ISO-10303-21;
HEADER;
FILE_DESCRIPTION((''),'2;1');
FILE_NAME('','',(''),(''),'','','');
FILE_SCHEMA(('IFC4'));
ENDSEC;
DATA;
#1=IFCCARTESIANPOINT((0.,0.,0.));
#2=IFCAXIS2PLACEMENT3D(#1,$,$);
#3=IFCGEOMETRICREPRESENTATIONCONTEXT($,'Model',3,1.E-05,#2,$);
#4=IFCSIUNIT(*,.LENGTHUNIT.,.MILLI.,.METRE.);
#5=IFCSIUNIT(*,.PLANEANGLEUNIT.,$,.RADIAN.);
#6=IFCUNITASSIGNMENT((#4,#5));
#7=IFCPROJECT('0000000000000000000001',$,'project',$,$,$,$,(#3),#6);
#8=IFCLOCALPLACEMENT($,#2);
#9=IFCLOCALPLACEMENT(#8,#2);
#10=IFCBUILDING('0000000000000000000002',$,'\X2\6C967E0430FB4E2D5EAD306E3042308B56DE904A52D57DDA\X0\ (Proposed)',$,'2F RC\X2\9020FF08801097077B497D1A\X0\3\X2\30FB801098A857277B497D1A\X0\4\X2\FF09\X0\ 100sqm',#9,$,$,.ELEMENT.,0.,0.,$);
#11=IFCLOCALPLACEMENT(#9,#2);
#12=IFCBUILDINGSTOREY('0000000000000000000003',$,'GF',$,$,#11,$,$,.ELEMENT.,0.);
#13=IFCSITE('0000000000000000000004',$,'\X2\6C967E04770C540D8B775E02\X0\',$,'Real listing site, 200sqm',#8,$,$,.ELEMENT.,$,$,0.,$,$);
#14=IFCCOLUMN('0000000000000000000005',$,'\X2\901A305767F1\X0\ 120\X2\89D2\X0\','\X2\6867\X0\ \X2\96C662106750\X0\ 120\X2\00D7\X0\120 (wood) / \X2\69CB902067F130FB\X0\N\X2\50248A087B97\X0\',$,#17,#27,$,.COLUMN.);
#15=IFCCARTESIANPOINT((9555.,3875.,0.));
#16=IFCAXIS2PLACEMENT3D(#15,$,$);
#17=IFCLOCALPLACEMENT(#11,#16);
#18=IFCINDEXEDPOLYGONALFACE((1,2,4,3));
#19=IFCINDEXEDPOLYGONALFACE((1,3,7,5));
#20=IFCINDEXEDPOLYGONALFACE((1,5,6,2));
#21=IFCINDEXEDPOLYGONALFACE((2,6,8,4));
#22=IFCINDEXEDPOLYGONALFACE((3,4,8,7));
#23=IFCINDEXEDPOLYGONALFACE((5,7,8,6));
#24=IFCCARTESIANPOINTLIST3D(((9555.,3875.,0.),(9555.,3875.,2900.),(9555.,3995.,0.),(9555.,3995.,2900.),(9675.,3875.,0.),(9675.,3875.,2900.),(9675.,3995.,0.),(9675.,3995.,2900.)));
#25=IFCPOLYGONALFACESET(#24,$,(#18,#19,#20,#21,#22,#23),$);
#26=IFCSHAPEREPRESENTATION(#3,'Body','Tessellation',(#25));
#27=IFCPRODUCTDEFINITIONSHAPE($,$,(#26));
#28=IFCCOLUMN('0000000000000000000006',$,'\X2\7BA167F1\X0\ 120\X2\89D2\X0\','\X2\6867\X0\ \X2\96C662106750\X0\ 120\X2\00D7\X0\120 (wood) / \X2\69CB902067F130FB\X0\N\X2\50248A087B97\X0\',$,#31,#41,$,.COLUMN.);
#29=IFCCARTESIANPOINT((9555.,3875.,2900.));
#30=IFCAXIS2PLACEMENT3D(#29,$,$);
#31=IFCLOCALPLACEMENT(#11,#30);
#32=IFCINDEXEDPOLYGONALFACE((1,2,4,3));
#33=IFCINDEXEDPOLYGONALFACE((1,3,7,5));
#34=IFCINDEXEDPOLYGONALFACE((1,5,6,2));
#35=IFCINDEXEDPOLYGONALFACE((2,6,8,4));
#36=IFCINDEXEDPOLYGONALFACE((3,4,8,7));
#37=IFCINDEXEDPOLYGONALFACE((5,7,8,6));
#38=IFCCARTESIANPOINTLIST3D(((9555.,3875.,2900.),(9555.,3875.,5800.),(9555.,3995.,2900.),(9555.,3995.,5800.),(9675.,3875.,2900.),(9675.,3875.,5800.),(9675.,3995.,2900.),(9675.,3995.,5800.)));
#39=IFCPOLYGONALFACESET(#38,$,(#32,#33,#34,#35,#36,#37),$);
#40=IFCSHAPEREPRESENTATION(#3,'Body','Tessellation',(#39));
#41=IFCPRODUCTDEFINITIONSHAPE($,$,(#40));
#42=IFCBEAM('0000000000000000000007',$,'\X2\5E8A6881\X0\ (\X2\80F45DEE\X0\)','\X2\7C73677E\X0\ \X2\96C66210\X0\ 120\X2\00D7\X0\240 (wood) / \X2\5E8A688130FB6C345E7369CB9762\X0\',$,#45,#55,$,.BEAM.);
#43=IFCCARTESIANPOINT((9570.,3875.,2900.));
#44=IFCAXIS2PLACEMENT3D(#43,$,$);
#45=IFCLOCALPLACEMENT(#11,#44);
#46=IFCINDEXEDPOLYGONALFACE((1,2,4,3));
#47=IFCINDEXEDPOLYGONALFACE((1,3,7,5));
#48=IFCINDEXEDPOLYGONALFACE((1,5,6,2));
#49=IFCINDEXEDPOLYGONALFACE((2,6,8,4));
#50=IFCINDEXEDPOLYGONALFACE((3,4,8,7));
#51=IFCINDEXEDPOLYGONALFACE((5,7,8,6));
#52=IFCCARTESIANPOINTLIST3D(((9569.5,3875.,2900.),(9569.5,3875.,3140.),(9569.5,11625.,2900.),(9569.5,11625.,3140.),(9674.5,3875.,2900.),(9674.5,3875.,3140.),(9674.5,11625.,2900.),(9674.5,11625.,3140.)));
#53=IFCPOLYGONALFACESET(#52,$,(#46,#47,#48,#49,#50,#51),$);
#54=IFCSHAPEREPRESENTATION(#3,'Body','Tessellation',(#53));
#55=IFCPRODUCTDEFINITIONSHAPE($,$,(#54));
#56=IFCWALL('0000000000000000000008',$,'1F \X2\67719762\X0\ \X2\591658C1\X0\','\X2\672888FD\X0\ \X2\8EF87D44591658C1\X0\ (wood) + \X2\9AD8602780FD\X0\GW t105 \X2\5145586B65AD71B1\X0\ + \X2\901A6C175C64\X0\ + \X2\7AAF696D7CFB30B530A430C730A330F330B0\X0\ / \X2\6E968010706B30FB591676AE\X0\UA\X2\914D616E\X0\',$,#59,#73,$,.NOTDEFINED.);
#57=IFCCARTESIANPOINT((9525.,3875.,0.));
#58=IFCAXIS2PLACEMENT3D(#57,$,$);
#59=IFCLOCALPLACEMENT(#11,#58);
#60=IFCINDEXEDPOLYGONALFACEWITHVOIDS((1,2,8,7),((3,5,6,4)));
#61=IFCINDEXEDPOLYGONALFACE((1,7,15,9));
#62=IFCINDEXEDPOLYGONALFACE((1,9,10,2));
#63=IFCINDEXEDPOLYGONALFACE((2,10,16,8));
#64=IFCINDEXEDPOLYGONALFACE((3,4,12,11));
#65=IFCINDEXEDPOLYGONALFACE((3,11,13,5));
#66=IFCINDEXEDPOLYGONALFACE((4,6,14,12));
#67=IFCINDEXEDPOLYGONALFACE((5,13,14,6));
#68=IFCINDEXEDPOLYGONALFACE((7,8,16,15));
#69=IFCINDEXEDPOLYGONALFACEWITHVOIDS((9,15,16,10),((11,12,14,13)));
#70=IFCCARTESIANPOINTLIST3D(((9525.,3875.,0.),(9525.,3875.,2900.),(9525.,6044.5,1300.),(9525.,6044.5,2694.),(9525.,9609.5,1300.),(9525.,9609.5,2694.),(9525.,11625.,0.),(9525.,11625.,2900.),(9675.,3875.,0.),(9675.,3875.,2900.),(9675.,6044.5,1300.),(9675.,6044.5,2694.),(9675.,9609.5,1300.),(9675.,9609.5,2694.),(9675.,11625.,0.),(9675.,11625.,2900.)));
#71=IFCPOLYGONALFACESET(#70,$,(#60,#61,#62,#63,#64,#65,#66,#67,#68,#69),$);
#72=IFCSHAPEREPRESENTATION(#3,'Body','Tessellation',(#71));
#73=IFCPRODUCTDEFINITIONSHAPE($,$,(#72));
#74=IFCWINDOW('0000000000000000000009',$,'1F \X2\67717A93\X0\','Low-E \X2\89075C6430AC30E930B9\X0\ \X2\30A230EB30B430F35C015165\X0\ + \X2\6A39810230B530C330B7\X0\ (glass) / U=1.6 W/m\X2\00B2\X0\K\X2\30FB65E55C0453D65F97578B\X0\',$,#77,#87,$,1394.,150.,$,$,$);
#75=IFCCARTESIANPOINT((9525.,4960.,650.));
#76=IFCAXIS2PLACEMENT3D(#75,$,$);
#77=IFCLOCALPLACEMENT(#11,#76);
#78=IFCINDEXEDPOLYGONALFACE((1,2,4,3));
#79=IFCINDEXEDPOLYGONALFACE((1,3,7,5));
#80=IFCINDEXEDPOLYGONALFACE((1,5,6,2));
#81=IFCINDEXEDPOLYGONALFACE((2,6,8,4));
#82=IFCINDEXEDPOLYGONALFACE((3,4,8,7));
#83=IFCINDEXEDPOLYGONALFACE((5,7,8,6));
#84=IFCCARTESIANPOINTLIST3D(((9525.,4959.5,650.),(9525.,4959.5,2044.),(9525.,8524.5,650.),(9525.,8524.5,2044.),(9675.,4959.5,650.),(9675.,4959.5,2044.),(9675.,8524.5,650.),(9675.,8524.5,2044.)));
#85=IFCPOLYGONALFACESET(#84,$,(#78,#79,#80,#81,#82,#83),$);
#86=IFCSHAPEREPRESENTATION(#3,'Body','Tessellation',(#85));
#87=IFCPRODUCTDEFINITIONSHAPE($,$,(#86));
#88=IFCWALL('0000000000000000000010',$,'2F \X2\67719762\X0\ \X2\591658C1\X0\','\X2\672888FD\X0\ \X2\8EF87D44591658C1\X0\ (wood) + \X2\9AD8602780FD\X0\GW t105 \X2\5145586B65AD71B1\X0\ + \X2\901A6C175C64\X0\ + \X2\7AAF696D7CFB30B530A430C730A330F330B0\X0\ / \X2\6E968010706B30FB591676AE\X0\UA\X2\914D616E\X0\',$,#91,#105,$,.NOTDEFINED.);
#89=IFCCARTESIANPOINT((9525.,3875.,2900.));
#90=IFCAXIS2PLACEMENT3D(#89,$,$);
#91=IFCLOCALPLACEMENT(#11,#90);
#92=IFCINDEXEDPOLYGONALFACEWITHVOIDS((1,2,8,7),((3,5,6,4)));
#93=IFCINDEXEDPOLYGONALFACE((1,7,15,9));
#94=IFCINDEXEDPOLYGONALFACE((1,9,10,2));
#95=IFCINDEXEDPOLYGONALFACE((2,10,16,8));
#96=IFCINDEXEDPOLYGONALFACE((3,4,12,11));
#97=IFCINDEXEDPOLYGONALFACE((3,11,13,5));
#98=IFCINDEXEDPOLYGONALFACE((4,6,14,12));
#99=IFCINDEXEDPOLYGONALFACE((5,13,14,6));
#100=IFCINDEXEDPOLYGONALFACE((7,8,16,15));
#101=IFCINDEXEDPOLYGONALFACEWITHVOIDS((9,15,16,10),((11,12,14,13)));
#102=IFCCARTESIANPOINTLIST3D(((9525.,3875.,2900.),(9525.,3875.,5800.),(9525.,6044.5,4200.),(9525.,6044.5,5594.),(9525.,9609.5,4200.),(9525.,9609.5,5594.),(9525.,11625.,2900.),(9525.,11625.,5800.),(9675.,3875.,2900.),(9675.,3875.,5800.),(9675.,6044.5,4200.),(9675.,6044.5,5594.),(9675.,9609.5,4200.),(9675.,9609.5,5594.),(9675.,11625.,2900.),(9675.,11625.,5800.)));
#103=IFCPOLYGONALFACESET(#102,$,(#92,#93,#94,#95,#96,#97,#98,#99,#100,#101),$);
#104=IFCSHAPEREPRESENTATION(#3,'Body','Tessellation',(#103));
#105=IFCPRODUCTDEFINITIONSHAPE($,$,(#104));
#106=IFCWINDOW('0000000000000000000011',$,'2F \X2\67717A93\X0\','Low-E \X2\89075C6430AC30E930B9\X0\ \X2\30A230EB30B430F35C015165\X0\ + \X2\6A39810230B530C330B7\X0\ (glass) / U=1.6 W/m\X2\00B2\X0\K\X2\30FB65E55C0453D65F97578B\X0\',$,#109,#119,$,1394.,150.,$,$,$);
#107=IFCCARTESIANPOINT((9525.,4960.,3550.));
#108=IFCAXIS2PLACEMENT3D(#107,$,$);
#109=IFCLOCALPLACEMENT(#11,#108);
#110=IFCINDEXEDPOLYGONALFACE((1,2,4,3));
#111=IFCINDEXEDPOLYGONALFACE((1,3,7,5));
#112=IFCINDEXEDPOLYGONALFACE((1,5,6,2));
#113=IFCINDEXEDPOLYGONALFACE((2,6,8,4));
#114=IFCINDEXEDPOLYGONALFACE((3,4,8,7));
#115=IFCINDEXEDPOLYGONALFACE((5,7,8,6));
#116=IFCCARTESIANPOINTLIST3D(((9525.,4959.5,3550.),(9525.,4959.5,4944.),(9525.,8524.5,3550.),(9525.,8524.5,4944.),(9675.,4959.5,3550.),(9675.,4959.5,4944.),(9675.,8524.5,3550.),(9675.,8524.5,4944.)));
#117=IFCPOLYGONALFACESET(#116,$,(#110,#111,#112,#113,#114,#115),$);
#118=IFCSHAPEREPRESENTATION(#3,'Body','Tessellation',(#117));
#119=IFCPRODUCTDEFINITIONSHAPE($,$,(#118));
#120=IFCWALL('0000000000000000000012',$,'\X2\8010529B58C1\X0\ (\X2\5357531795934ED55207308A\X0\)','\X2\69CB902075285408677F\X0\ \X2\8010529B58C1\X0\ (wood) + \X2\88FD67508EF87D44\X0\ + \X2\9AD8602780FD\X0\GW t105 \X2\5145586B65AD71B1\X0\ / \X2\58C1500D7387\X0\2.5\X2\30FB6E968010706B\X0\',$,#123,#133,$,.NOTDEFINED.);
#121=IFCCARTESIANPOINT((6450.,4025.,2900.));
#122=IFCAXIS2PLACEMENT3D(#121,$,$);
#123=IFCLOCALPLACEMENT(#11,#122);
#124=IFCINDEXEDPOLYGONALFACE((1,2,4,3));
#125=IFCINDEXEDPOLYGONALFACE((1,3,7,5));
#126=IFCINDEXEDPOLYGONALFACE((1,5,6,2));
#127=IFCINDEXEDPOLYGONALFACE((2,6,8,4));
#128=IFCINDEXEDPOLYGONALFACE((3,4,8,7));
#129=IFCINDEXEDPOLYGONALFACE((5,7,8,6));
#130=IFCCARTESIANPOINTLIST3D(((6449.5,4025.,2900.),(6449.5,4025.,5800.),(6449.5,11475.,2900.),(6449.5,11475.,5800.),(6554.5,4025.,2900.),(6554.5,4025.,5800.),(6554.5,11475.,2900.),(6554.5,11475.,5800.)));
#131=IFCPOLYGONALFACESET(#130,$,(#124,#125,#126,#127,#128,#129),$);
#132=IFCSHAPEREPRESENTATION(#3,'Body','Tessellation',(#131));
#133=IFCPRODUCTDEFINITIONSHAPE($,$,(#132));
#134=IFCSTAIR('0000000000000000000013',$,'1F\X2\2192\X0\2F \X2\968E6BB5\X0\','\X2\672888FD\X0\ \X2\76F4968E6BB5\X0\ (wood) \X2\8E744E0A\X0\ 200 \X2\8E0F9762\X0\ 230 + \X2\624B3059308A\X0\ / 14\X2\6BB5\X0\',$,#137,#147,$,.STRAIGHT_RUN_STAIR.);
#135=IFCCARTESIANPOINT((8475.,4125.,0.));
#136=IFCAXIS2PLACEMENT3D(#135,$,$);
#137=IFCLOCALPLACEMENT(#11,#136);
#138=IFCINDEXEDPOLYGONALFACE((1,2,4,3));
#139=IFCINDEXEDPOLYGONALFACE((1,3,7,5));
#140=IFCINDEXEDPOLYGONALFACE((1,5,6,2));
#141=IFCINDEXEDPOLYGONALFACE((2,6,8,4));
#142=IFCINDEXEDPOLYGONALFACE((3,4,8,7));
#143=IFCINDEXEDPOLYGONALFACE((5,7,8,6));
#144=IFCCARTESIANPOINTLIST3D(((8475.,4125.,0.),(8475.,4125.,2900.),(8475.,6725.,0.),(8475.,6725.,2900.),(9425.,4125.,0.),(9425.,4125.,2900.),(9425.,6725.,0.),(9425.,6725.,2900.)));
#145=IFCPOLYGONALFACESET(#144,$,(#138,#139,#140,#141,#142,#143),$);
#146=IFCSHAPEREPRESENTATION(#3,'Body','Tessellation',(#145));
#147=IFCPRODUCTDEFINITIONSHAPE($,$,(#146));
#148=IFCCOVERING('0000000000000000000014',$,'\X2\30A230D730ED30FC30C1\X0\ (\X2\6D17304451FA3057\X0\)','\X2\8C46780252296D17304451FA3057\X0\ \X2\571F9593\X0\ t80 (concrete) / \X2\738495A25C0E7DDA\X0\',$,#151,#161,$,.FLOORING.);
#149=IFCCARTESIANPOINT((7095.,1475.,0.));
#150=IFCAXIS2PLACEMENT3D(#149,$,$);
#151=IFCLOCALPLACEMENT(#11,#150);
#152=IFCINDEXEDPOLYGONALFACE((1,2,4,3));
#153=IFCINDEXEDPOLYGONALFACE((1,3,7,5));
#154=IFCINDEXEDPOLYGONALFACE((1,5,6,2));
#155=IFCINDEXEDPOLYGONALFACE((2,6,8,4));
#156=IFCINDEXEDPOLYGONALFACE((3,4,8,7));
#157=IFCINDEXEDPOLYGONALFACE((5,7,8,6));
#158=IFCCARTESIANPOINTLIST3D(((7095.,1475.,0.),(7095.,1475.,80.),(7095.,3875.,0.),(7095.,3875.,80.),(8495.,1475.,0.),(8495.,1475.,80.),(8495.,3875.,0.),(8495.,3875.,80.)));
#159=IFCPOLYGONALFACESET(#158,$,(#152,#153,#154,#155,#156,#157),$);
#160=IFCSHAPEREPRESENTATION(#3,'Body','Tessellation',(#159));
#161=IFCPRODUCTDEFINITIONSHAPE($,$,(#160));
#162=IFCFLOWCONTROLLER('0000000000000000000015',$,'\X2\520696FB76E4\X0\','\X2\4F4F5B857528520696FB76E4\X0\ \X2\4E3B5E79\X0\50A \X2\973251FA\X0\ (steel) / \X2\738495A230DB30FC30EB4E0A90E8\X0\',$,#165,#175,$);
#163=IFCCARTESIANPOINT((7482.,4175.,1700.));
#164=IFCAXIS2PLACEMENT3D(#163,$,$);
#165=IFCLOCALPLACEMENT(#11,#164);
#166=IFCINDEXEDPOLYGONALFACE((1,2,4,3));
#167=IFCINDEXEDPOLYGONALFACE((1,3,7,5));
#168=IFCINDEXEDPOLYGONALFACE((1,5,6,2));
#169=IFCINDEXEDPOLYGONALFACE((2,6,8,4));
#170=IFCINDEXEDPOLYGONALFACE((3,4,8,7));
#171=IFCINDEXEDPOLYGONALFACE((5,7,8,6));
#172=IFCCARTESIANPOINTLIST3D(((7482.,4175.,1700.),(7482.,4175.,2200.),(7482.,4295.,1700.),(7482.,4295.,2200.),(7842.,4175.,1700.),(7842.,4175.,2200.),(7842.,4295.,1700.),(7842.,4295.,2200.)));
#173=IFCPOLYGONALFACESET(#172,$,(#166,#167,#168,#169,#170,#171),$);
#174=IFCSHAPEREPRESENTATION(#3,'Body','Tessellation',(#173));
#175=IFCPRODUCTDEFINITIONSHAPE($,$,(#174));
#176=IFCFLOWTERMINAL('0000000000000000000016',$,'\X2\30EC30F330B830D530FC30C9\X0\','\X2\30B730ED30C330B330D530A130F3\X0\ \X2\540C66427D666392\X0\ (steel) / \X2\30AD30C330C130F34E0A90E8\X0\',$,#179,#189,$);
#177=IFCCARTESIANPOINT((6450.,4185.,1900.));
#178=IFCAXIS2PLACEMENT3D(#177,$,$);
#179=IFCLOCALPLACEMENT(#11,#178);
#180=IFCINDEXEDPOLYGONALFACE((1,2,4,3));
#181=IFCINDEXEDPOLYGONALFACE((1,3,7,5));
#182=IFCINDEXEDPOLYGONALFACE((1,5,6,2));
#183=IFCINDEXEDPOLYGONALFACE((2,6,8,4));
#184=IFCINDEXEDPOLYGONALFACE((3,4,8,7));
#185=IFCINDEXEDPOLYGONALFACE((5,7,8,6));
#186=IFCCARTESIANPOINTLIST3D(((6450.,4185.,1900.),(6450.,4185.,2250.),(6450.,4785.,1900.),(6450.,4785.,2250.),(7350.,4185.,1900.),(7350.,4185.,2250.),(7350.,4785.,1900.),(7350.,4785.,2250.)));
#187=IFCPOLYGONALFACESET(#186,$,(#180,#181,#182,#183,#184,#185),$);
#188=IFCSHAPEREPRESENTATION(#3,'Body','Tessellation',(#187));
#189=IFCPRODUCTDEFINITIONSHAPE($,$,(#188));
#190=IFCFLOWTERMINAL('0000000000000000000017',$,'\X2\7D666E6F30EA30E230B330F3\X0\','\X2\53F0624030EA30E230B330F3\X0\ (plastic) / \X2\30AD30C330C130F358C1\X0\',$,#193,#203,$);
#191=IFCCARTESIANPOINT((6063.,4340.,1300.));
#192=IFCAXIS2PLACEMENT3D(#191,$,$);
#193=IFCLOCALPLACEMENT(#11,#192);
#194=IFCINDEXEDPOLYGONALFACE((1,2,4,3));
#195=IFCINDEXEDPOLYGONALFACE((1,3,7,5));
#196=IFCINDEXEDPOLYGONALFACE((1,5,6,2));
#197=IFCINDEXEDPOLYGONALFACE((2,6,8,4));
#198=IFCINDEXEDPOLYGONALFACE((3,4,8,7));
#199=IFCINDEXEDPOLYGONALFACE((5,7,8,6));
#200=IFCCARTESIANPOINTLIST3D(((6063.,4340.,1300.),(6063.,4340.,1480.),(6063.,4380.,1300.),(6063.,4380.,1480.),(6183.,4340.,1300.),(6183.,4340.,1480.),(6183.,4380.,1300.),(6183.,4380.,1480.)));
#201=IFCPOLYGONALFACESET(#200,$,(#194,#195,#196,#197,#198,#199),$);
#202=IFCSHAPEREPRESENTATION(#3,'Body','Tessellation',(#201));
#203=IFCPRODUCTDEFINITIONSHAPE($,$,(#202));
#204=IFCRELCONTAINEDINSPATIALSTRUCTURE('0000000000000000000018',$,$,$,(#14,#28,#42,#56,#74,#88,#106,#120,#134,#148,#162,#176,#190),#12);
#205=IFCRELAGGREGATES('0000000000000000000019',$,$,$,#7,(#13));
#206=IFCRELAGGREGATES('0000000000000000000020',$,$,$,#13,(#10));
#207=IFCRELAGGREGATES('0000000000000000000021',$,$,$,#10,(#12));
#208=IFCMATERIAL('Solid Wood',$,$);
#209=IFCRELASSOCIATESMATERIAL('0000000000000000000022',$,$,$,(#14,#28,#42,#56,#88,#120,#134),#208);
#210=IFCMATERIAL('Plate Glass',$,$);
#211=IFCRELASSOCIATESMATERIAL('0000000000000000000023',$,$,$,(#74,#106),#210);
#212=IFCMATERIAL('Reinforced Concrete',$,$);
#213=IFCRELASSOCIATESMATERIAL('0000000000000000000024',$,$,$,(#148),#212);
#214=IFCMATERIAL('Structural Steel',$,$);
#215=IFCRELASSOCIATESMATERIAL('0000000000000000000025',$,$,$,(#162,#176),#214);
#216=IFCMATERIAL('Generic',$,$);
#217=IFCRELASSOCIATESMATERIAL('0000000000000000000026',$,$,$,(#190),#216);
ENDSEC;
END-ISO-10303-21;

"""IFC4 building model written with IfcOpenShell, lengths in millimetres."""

from ifc_helpers import new_model, si_unit, frame, frame_2d, origin, place, context, project, spatial, rectangle, extrude, material, element, fill, save


model = new_model("IFC4")

# Units and contexts
model_context = context("Model", 3, precision=1e-05, world=origin())
ifc_project = project(units=[si_unit("LENGTHUNIT", "METRE", prefix="MILLI"), si_unit("PLANEANGLEUNIT", "RADIAN")], contexts=[model_context])

# Site, building, storey
site_placement = place(None, origin())
site = spatial("IfcSite", under=ifc_project, at=site_placement, Name="沖縄県名護市", ObjectType="Real listing site, 200sqm", CompositionType="ELEMENT", RefElevation=0.0)
building_placement = place(site_placement, origin())
building = spatial("IfcBuilding", under=site, at=building_placement, Name="沖縄・中庭のある回遊動線 (Proposed)", ObjectType="2F RC造（耐震等級3・耐風圧等級4） 100sqm", CompositionType="ELEMENT", ElevationOfRefHeight=0.0, ElevationOfTerrain=0.0)
storey_placement = place(building_placement, origin())
storey = spatial("IfcBuildingStorey", under=building, at=storey_placement, Name="GF", CompositionType="ELEMENT", Elevation=0.0)

# Columns
ifc_material_1 = material(Name="Solid Wood")
column_1_placement = place(storey_placement, frame((9555.0, 3875.0, 0.0)))
element("IfcColumn", 1, at=column_1_placement, inside=storey, material=ifc_material_1, Name="通し柱 120角", Description="桧 集成材 120×120 (wood) / 構造柱・N値計算", PredefinedType="COLUMN", context=model_context, shape_type="SweptSolid", body=[
    extrude(rectangle(XDim=120.0, YDim=120.0, at=frame_2d((60.0, 60.0))), frame((9555.0, 3875.0, 0.0)), (0.0, 0.0, 1.0), 2900.0),
])
column_2_placement = place(storey_placement, frame((9555.0, 3875.0, 2900.0)))
element("IfcColumn", 2, at=column_2_placement, inside=storey, material=ifc_material_1, Name="管柱 120角", Description="桧 集成材 120×120 (wood) / 構造柱・N値計算", PredefinedType="COLUMN", context=model_context, shape_type="SweptSolid", body=[
    extrude(rectangle(XDim=120.0, YDim=120.0, at=frame_2d((60.0, 60.0))), frame((9555.0, 3875.0, 2900.0)), (0.0, 0.0, 1.0), 2900.0),
])

# Beam
beam_1_placement = place(storey_placement, frame((9570.0, 3875.0, 2900.0)))
element("IfcBeam", 3, at=beam_1_placement, inside=storey, material=ifc_material_1, Name="床梁 (胴差)", Description="米松 集成 120×240 (wood) / 床梁・水平構面", PredefinedType="BEAM", context=model_context, shape_type="SweptSolid", body=[
    extrude(rectangle(XDim=105.0, YDim=7750.0, at=frame_2d((52.0, 3875.0))), frame((9570.0, 3875.0, 2900.0)), (0.0, 0.0, 1.0), 240.0),
])

# Wall, opening, window
wall_1_placement = place(storey_placement, frame((9525.0, 3875.0, 0.0)))
wall_1 = element("IfcWall", 4, at=wall_1_placement, inside=storey, material=ifc_material_1, Name="1F 東面 外壁", Description="木製 軸組外壁 (wood) + 高性能GW t105 充填断熱 + 通気層 + 窯業系サイディング / 準耐火・外皮UA配慮", PredefinedType="NOTDEFINED", context=model_context, shape_type="SweptSolid", body=[
    extrude(rectangle(XDim=150.0, YDim=7750.0, at=frame_2d((75.0, 3875.0))), frame((9525.0, 3875.0, 0.0)), (0.0, 0.0, 1.0), 2900.0),
])
opening_1_placement = place(storey_placement, frame((9525.0, 4960.0, 650.0)))
opening_1 = element("IfcOpeningElement", 5, at=opening_1_placement, cuts=wall_1, PredefinedType="NOTDEFINED", context=model_context, shape_type="SweptSolid", body=[
    extrude(rectangle(XDim=150.0, YDim=3565.0, at=frame_2d((75.0, 1782.0))), frame((9525.0, 4960.0, 650.0)), (0.0, 0.0, 1.0), 1394.0),
])
ifc_material_2 = material(Name="Plate Glass")
window_1_placement = place(storey_placement, frame((9525.0, 4960.0, 650.0)))
window_1 = element("IfcWindow", 6, at=window_1_placement, inside=storey, material=ifc_material_2, Name="1F 東窓", Description="Low-E 複層ガラス アルゴン封入 + 樹脂サッシ (glass) / U=1.6 W/m²K・日射取得型", OverallHeight=1394.0, OverallWidth=150.0, context=model_context, shape_type="SweptSolid", body=[
    extrude(rectangle(XDim=150.0, YDim=3565.0, at=frame_2d((75.0, 1782.0))), frame((9525.0, 4960.0, 650.0)), (0.0, 0.0, 1.0), 1394.0),
])
fill(opening_1, window_1)

# Wall, opening, window
wall_2_placement = place(storey_placement, frame((9525.0, 3875.0, 2900.0)))
wall_2 = element("IfcWall", 7, at=wall_2_placement, inside=storey, material=ifc_material_1, Name="2F 東面 外壁", Description="木製 軸組外壁 (wood) + 高性能GW t105 充填断熱 + 通気層 + 窯業系サイディング / 準耐火・外皮UA配慮", PredefinedType="NOTDEFINED", context=model_context, shape_type="SweptSolid", body=[
    extrude(rectangle(XDim=150.0, YDim=7750.0, at=frame_2d((75.0, 3875.0))), frame((9525.0, 3875.0, 2900.0)), (0.0, 0.0, 1.0), 2900.0),
])
opening_2_placement = place(storey_placement, frame((9525.0, 4960.0, 3550.0)))
opening_2 = element("IfcOpeningElement", 8, at=opening_2_placement, cuts=wall_2, PredefinedType="NOTDEFINED", context=model_context, shape_type="SweptSolid", body=[
    extrude(rectangle(XDim=150.0, YDim=3565.0, at=frame_2d((75.0, 1782.0))), frame((9525.0, 4960.0, 3550.0)), (0.0, 0.0, 1.0), 1394.0),
])
window_2_placement = place(storey_placement, frame((9525.0, 4960.0, 3550.0)))
window_2 = element("IfcWindow", 9, at=window_2_placement, inside=storey, material=ifc_material_2, Name="2F 東窓", Description="Low-E 複層ガラス アルゴン封入 + 樹脂サッシ (glass) / U=1.6 W/m²K・日射取得型", OverallHeight=1394.0, OverallWidth=150.0, context=model_context, shape_type="SweptSolid", body=[
    extrude(rectangle(XDim=150.0, YDim=3565.0, at=frame_2d((75.0, 1782.0))), frame((9525.0, 4960.0, 3550.0)), (0.0, 0.0, 1.0), 1394.0),
])
fill(opening_2, window_2)

# Wall
wall_3_placement = place(storey_placement, frame((6450.0, 4025.0, 2900.0)))
element("IfcWall", 10, at=wall_3_placement, inside=storey, material=ifc_material_1, Name="耐力壁 (南北間仕切り)", Description="構造用合板 耐力壁 (wood) + 製材軸組 + 高性能GW t105 充填断熱 / 壁倍率2.5・準耐火", PredefinedType="NOTDEFINED", context=model_context, shape_type="SweptSolid", body=[
    extrude(rectangle(XDim=105.0, YDim=7450.0, at=frame_2d((52.0, 3725.0))), frame((6450.0, 4025.0, 2900.0)), (0.0, 0.0, 1.0), 2900.0),
])

# Stair
stair_placement = place(storey_placement, frame((8475.0, 4125.0, 0.0)))
element("IfcStair", 11, at=stair_placement, inside=storey, material=ifc_material_1, Name="1F→2F 階段", Description="木製 直階段 (wood) 蹴上 200 踏面 230 + 手すり / 14段", PredefinedType="STRAIGHT_RUN_STAIR", context=model_context, shape_type="SweptSolid", body=[
    extrude(rectangle(XDim=950.0, YDim=2600.0, at=frame_2d((475.0, 1300.0))), frame((8475.0, 4125.0, 0.0)), (0.0, 0.0, 1.0), 2900.0),
])

# Covering
ifc_material_3 = material(Name="Reinforced Concrete")
covering_placement = place(storey_placement, frame((7095.0, 1475.0, 0.0)))
element("IfcCovering", 12, at=covering_placement, inside=storey, material=ifc_material_3, Name="アプローチ (洗い出し)", Description="豆砂利洗い出し 土間 t80 (concrete) / 玄関導線", PredefinedType="FLOORING", context=model_context, shape_type="SweptSolid", body=[
    extrude(rectangle(XDim=1400.0, YDim=2400.0, at=frame_2d((700.0, 1200.0))), frame((7095.0, 1475.0, 0.0)), (0.0, 0.0, 1.0), 80.0),
])

# Flow controller
ifc_material_4 = material(Name="Structural Steel")
flow_controller_placement = place(storey_placement, frame((7482.0, 4175.0, 1700.0)))
element("IfcFlowController", 13, at=flow_controller_placement, inside=storey, material=ifc_material_4, Name="分電盤", Description="住宅用分電盤 主幹50A 露出 (steel) / 玄関ホール上部", context=model_context, shape_type="SweptSolid", body=[
    extrude(rectangle(XDim=360.0, YDim=120.0, at=frame_2d((180.0, 60.0))), frame((7482.0, 4175.0, 1700.0)), (0.0, 0.0, 1.0), 500.0),
])

# Flow terminals
flow_terminal_1_placement = place(storey_placement, frame((6450.0, 4185.0, 1900.0)))
element("IfcFlowTerminal", 14, at=flow_terminal_1_placement, inside=storey, material=ifc_material_4, Name="レンジフード", Description="シロッコファン 同時給排 (steel) / キッチン上部", context=model_context, shape_type="SweptSolid", body=[
    extrude(rectangle(XDim=900.0, YDim=600.0, at=frame_2d((450.0, 300.0))), frame((6450.0, 4185.0, 1900.0)), (0.0, 0.0, 1.0), 350.0),
])
ifc_material_5 = material(Name="Generic")
flow_terminal_2_placement = place(storey_placement, frame((6063.0, 4340.0, 1300.0)))
element("IfcFlowTerminal", 15, at=flow_terminal_2_placement, inside=storey, material=ifc_material_5, Name="給湯リモコン", Description="台所リモコン (plastic) / キッチン壁", context=model_context, shape_type="SweptSolid", body=[
    extrude(rectangle(XDim=120.0, YDim=40.0, at=frame_2d((60.0, 20.0))), frame((6063.0, 4340.0, 1300.0)), (0.0, 0.0, 1.0), 180.0),
])

save(model, "model.ifc")
